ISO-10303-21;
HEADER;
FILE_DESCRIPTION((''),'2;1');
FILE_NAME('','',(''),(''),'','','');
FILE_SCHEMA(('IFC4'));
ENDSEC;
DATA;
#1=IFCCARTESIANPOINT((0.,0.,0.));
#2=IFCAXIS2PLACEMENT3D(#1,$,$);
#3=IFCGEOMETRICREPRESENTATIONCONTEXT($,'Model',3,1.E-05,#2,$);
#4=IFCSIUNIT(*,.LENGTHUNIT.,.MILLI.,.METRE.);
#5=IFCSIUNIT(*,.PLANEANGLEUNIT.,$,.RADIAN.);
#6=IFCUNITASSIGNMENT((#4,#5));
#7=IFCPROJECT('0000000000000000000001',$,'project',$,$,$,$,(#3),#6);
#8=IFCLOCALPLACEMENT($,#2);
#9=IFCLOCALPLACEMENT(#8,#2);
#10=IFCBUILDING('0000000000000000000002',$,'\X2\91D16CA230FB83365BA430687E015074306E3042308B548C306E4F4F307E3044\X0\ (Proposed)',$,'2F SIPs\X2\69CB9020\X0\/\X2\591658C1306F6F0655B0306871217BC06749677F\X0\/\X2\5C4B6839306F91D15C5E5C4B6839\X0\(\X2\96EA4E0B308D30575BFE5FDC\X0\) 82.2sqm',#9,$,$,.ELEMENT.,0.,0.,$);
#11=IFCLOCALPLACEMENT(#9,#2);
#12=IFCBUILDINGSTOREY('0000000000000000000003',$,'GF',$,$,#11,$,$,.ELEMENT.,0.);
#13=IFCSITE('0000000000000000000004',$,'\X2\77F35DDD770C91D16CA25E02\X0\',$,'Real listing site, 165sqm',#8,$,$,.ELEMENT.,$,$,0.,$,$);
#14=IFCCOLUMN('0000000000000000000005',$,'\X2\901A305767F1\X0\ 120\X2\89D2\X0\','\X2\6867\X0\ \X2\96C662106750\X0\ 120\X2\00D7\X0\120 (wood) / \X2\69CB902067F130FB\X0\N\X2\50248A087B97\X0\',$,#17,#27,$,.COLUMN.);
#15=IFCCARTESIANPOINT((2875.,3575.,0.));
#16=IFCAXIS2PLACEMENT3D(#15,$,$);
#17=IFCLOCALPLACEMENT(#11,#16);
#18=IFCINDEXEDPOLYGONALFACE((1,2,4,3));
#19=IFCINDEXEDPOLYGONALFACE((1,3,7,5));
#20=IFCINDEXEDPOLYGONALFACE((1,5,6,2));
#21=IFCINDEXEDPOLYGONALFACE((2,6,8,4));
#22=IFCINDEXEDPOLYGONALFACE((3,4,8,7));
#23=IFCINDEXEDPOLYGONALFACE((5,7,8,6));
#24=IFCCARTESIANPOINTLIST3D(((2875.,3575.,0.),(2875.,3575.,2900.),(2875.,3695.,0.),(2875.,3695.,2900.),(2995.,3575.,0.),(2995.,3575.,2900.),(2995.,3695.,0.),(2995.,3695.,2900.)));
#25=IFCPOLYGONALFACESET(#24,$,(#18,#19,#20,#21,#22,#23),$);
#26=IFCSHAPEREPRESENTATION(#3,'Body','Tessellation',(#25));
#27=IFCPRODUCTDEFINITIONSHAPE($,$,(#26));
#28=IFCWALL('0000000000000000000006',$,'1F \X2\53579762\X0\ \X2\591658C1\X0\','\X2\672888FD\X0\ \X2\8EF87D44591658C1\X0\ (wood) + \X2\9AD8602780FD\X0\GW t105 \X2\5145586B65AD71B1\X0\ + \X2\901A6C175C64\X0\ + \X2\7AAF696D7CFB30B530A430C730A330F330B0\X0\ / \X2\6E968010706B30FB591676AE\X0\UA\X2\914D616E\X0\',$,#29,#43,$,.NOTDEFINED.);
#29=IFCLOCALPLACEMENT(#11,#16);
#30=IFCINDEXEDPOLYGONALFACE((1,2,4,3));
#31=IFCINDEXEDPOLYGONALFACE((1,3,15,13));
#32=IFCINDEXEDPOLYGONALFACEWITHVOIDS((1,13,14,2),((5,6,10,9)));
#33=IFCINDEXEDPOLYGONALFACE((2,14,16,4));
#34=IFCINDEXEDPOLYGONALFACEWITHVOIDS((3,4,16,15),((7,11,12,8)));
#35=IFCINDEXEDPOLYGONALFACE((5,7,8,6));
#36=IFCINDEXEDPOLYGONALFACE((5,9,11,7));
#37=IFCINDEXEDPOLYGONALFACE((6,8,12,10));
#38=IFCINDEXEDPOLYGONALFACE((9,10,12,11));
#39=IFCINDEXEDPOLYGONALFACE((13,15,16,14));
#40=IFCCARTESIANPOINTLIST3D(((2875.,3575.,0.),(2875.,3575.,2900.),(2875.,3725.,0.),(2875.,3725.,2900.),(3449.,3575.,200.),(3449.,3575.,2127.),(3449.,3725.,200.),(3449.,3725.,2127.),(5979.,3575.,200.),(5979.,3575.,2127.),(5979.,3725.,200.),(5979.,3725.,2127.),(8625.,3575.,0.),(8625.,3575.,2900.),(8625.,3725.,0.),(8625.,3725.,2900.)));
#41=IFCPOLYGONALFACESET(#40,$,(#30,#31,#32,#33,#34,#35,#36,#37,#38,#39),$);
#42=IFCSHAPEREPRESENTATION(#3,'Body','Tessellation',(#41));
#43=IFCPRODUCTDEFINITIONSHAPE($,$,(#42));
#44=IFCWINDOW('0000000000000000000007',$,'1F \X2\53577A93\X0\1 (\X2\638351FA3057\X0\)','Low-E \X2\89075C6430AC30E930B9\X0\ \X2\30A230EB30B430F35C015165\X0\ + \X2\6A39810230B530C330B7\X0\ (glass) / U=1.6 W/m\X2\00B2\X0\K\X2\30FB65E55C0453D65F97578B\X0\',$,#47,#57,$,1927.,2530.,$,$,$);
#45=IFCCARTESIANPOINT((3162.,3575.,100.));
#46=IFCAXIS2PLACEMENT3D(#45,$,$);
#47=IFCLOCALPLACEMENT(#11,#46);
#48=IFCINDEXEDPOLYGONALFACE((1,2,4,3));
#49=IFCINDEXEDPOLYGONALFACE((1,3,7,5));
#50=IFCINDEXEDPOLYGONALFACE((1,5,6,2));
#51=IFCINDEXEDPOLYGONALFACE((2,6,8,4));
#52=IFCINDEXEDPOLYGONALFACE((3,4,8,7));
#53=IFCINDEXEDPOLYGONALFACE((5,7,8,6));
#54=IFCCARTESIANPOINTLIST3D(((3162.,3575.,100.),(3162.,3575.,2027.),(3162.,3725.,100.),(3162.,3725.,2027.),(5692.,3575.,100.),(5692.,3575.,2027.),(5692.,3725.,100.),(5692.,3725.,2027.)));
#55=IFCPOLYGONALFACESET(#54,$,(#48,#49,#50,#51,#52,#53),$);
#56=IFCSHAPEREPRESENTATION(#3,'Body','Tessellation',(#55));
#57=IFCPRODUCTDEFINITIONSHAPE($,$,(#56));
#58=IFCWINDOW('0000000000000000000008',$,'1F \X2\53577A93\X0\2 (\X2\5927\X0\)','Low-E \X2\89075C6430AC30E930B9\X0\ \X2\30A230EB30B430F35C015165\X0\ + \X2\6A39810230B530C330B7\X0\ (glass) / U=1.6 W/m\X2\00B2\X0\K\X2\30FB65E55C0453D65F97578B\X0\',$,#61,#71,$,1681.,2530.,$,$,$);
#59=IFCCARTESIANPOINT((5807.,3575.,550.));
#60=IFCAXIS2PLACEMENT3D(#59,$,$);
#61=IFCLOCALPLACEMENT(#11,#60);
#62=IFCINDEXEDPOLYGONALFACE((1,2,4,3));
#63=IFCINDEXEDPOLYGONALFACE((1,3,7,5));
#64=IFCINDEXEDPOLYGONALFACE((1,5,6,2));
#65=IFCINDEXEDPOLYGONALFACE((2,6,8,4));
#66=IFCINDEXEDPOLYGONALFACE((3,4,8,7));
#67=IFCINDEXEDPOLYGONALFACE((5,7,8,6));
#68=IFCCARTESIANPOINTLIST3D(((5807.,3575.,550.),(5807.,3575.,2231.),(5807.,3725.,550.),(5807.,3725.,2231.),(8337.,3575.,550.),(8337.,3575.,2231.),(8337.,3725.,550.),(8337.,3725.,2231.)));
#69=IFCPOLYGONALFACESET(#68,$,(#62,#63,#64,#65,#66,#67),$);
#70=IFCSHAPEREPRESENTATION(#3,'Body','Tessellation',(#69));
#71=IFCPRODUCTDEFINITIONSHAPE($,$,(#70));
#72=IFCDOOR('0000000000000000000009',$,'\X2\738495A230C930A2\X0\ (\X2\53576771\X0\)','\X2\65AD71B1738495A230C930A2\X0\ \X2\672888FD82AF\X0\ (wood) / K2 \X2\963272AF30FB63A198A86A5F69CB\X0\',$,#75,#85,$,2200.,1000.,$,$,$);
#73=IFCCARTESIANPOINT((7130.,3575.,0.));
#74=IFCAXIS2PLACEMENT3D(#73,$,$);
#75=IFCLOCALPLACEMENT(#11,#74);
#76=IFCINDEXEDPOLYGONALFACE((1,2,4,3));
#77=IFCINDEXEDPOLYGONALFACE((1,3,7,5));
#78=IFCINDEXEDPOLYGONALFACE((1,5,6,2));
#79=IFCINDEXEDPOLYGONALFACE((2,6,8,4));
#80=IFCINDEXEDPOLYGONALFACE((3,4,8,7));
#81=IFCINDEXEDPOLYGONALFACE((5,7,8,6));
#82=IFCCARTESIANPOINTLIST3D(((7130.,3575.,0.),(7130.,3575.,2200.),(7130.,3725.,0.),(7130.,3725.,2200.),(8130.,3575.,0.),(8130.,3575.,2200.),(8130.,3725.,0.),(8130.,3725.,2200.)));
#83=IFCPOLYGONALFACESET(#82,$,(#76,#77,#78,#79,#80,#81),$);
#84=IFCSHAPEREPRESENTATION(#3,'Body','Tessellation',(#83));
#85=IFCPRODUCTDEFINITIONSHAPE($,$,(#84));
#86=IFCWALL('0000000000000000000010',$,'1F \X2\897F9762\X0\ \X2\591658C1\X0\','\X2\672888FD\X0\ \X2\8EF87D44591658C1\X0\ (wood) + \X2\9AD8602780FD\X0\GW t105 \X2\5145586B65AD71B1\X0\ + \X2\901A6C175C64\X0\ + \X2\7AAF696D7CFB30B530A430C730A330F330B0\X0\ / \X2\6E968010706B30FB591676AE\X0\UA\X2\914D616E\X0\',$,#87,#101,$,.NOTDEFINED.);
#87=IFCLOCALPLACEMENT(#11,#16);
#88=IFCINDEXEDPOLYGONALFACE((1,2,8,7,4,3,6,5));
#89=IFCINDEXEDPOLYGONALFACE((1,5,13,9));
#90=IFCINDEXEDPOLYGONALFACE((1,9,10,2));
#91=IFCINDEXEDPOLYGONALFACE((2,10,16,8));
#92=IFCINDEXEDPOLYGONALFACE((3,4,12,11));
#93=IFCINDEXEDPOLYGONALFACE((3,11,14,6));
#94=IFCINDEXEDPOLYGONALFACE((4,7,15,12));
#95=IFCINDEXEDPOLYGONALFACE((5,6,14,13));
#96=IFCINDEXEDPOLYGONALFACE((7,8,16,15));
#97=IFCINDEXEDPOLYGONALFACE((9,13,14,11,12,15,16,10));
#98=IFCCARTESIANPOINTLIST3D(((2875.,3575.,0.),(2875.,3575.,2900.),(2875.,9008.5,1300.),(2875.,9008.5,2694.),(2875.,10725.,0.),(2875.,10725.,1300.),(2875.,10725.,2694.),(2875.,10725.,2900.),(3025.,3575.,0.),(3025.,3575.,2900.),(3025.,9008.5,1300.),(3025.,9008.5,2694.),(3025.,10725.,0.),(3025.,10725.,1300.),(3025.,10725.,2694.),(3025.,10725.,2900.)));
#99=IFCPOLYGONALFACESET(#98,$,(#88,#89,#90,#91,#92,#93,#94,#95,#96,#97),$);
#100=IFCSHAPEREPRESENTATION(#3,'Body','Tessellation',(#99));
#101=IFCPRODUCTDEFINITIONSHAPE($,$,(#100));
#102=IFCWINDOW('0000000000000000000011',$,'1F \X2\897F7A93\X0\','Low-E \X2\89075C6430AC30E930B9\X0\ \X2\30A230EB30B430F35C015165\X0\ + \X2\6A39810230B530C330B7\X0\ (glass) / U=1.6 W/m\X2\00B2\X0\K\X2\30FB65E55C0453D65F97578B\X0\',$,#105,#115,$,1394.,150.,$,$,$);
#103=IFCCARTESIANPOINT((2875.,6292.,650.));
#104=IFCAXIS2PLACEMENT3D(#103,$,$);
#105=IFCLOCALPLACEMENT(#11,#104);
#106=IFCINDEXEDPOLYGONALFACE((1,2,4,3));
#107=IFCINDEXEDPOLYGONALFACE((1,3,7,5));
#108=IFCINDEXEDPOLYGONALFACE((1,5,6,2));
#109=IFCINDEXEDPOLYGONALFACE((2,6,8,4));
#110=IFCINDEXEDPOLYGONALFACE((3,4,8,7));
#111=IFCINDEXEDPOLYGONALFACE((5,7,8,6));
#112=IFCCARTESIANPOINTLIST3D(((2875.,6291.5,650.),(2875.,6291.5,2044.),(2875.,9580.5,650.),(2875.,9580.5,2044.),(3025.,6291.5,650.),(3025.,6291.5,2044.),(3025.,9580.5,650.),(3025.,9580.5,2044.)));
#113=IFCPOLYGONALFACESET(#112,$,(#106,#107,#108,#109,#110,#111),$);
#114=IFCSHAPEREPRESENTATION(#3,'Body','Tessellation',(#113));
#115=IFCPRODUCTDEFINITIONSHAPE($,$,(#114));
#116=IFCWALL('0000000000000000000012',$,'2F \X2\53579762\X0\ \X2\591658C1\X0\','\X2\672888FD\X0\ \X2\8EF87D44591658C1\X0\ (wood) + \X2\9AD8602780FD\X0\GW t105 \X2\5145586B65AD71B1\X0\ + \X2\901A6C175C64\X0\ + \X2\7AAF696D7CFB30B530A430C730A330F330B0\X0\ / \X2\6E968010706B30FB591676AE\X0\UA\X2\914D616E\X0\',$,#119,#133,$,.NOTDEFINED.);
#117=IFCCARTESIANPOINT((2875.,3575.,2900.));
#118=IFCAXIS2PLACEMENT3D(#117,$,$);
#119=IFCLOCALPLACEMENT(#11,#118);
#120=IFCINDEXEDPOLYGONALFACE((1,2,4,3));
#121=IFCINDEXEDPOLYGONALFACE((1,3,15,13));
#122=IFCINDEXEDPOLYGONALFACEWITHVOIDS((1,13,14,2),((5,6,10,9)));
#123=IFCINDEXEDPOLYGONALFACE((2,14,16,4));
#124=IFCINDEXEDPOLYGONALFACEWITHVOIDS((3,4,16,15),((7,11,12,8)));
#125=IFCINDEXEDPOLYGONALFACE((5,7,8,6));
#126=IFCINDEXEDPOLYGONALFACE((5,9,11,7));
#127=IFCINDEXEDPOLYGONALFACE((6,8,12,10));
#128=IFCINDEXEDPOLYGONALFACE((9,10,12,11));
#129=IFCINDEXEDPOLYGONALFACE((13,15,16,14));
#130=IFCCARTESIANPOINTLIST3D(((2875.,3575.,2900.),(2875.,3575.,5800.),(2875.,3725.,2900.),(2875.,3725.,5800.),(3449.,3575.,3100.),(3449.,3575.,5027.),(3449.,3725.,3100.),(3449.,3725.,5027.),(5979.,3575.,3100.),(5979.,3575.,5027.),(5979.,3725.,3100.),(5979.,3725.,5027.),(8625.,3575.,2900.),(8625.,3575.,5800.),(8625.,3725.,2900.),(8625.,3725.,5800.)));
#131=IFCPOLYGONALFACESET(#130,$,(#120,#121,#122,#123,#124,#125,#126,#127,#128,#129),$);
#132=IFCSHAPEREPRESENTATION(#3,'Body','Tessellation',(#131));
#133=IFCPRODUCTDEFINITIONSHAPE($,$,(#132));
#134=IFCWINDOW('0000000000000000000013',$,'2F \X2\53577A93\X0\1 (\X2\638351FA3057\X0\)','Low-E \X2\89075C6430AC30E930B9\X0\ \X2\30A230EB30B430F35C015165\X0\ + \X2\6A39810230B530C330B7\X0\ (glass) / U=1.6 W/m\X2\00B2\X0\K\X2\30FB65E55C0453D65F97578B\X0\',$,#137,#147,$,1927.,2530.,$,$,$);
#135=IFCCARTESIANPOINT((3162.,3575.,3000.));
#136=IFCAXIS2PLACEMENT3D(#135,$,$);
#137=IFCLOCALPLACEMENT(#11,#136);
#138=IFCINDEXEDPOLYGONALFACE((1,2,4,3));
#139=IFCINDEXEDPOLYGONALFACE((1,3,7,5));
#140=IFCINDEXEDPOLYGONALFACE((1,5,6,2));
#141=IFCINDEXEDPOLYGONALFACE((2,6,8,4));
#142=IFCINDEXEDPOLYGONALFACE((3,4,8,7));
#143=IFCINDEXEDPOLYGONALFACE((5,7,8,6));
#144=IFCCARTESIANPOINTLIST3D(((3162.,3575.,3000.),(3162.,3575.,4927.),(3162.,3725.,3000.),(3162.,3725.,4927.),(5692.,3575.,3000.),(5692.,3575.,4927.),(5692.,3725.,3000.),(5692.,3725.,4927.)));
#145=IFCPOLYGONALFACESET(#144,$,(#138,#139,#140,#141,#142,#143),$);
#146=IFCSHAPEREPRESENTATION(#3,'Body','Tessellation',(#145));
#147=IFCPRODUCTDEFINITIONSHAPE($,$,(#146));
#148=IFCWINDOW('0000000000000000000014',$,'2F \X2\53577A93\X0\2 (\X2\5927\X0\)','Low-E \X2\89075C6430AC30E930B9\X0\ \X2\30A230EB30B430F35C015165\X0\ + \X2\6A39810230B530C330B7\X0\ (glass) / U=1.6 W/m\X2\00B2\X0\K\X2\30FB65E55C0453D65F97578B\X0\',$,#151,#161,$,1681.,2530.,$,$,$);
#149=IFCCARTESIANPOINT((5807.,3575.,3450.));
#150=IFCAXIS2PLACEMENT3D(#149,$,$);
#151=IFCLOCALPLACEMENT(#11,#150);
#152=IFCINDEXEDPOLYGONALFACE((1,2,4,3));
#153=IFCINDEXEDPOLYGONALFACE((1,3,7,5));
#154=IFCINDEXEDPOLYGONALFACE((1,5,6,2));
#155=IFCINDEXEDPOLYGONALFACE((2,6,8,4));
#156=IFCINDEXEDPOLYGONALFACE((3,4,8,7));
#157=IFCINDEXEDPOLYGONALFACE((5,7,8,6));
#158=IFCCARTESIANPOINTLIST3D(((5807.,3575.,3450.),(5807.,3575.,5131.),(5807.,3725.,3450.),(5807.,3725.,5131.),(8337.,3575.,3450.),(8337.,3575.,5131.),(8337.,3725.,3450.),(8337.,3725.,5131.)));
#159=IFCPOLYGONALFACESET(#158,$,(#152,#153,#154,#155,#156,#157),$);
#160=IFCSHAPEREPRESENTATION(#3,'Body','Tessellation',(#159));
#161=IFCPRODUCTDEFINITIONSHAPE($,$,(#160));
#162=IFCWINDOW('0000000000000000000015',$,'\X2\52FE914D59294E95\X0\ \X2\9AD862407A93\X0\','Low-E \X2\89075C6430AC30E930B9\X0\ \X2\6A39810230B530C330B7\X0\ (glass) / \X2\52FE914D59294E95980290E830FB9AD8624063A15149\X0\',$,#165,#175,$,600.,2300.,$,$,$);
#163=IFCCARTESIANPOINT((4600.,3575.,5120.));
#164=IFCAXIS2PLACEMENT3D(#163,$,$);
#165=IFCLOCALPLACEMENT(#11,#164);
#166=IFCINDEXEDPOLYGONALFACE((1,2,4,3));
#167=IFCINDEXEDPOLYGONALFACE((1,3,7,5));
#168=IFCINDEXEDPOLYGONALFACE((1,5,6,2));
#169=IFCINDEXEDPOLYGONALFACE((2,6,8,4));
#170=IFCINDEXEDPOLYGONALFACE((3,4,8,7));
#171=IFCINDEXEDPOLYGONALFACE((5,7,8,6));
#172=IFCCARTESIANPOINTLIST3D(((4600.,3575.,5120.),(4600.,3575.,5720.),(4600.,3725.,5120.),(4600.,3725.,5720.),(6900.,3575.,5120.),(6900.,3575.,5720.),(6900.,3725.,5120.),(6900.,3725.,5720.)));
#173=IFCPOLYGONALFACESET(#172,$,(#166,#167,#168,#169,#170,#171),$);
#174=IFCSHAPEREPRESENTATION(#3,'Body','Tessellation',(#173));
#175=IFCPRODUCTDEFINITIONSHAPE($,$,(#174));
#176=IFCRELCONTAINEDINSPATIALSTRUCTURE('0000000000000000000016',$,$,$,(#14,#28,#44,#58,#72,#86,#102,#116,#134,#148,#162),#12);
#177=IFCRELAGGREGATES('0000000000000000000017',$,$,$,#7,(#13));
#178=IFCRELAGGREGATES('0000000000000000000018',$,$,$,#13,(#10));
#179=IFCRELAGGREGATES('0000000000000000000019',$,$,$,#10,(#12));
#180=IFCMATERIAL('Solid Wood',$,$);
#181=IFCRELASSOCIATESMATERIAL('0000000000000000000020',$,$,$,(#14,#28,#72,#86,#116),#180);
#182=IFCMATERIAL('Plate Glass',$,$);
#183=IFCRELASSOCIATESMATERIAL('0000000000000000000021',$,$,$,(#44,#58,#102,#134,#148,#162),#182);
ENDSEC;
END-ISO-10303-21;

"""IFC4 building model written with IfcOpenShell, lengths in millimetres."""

from ifc_helpers import new_model, si_unit, frame, frame_2d, origin, place, context, project, spatial, rectangle, extrude, material, element, fill, save


model = new_model("IFC4")

# Units and contexts
model_context = context("Model", 3, precision=1e-05, world=origin())
ifc_project = project(units=[si_unit("LENGTHUNIT", "METRE", prefix="MILLI"), si_unit("PLANEANGLEUNIT", "RADIAN")], contexts=[model_context])

# Site, building, storey
site_placement = place(None, origin())
site = spatial("IfcSite", under=ifc_project, at=site_placement, Name="石川県金沢市", ObjectType="Real listing site, 165sqm", CompositionType="ELEMENT", RefElevation=0.0)
building_placement = place(site_placement, origin())
building = spatial("IfcBuilding", under=site, at=building_placement, Name="金沢・茶室と縁側のある和の住まい (Proposed)", ObjectType="2F SIPs構造/外壁は漆喰と無節杉板/屋根は金属屋根(雪下ろし対応) 82.2sqm", CompositionType="ELEMENT", ElevationOfRefHeight=0.0, ElevationOfTerrain=0.0)
storey_placement = place(building_placement, origin())
storey = spatial("IfcBuildingStorey", under=building, at=storey_placement, Name="GF", CompositionType="ELEMENT", Elevation=0.0)

# Column
ifc_material_1 = material(Name="Solid Wood")
column_placement = place(storey_placement, frame((2875.0, 3575.0, 0.0)))
element("IfcColumn", 1, at=column_placement, inside=storey, material=ifc_material_1, Name="通し柱 120角", Description="桧 集成材 120×120 (wood) / 構造柱・N値計算", PredefinedType="COLUMN", context=model_context, shape_type="SweptSolid", body=[
    extrude(rectangle(XDim=120.0, YDim=120.0, at=frame_2d((60.0, 60.0))), frame((2875.0, 3575.0, 0.0)), (0.0, 0.0, 1.0), 2900.0),
])

# Wall, openings, windows, door
wall_1_placement = place(storey_placement, frame((2875.0, 3575.0, 0.0)))
wall_1 = element("IfcWall", 2, at=wall_1_placement, inside=storey, material=ifc_material_1, Name="1F 南面 外壁", Description="木製 軸組外壁 (wood) + 高性能GW t105 充填断熱 + 通気層 + 窯業系サイディング / 準耐火・外皮UA配慮", PredefinedType="NOTDEFINED", context=model_context, shape_type="SweptSolid", body=[
    extrude(rectangle(XDim=5750.0, YDim=150.0, at=frame_2d((2875.0, 75.0))), frame((2875.0, 3575.0, 0.0)), (0.0, 0.0, 1.0), 2900.0),
])
opening_1_placement = place(storey_placement, frame((3162.0, 3575.0, 100.0)))
opening_1 = element("IfcOpeningElement", 3, at=opening_1_placement, cuts=wall_1, PredefinedType="NOTDEFINED", context=model_context, shape_type="SweptSolid", body=[
    extrude(rectangle(XDim=2530.0, YDim=150.0, at=frame_2d((1265.0, 75.0))), frame((3162.0, 3575.0, 100.0)), (0.0, 0.0, 1.0), 1927.0),
])
opening_2_placement = place(storey_placement, frame((5807.0, 3575.0, 550.0)))
opening_2 = element("IfcOpeningElement", 4, at=opening_2_placement, cuts=wall_1, PredefinedType="NOTDEFINED", context=model_context, shape_type="SweptSolid", body=[
    extrude(rectangle(XDim=2530.0, YDim=150.0, at=frame_2d((1265.0, 75.0))), frame((5807.0, 3575.0, 550.0)), (0.0, 0.0, 1.0), 1681.0),
])
opening_3_placement = place(storey_placement, frame((7130.0, 3575.0, 0.0)))
opening_3 = element("IfcOpeningElement", 5, at=opening_3_placement, cuts=wall_1, PredefinedType="NOTDEFINED", context=model_context, shape_type="SweptSolid", body=[
    extrude(rectangle(XDim=1000.0, YDim=150.0, at=frame_2d((500.0, 75.0))), frame((7130.0, 3575.0, 0.0)), (0.0, 0.0, 1.0), 2200.0),
])
ifc_material_2 = material(Name="Plate Glass")
window_1_placement = place(storey_placement, frame((3162.0, 3575.0, 100.0)))
window_1 = element("IfcWindow", 6, at=window_1_placement, inside=storey, material=ifc_material_2, Name="1F 南窓1 (掃出し)", Description="Low-E 複層ガラス アルゴン封入 + 樹脂サッシ (glass) / U=1.6 W/m²K・日射取得型", OverallHeight=1927.0, OverallWidth=2530.0, context=model_context, shape_type="SweptSolid", body=[
    extrude(rectangle(XDim=2530.0, YDim=150.0, at=frame_2d((1265.0, 75.0))), frame((3162.0, 3575.0, 100.0)), (0.0, 0.0, 1.0), 1927.0),
])
fill(opening_1, window_1)
window_2_placement = place(storey_placement, frame((5807.0, 3575.0, 550.0)))
window_2 = element("IfcWindow", 7, at=window_2_placement, inside=storey, material=ifc_material_2, Name="1F 南窓2 (大)", Description="Low-E 複層ガラス アルゴン封入 + 樹脂サッシ (glass) / U=1.6 W/m²K・日射取得型", OverallHeight=1681.0, OverallWidth=2530.0, context=model_context, shape_type="SweptSolid", body=[
    extrude(rectangle(XDim=2530.0, YDim=150.0, at=frame_2d((1265.0, 75.0))), frame((5807.0, 3575.0, 550.0)), (0.0, 0.0, 1.0), 1681.0),
])
fill(opening_2, window_2)
door_placement = place(storey_placement, frame((7130.0, 3575.0, 0.0)))
door = element("IfcDoor", 8, at=door_placement, inside=storey, material=ifc_material_1, Name="玄関ドア (南東)", Description="断熱玄関ドア 木製芯 (wood) / K2 防犯・採風機構", OverallHeight=2200.0, OverallWidth=1000.0, context=model_context, shape_type="SweptSolid", body=[
    extrude(rectangle(XDim=1000.0, YDim=150.0, at=frame_2d((500.0, 75.0))), frame((7130.0, 3575.0, 0.0)), (0.0, 0.0, 1.0), 2200.0),
])
fill(opening_3, door)

# Wall, opening, window
wall_2_placement = place(storey_placement, frame((2875.0, 3575.0, 0.0)))
wall_2 = element("IfcWall", 9, at=wall_2_placement, inside=storey, material=ifc_material_1, Name="1F 西面 外壁", Description="木製 軸組外壁 (wood) + 高性能GW t105 充填断熱 + 通気層 + 窯業系サイディング / 準耐火・外皮UA配慮", PredefinedType="NOTDEFINED", context=model_context, shape_type="SweptSolid", body=[
    extrude(rectangle(XDim=150.0, YDim=7150.0, at=frame_2d((75.0, 3575.0))), frame((2875.0, 3575.0, 0.0)), (0.0, 0.0, 1.0), 2900.0),
])
opening_4_placement = place(storey_placement, frame((2875.0, 6292.0, 650.0)))
opening_4 = element("IfcOpeningElement", 10, at=opening_4_placement, cuts=wall_2, PredefinedType="NOTDEFINED", context=model_context, shape_type="SweptSolid", body=[
    extrude(rectangle(XDim=150.0, YDim=3289.0, at=frame_2d((75.0, 1644.0))), frame((2875.0, 6292.0, 650.0)), (0.0, 0.0, 1.0), 1394.0),
])
window_3_placement = place(storey_placement, frame((2875.0, 6292.0, 650.0)))
window_3 = element("IfcWindow", 11, at=window_3_placement, inside=storey, material=ifc_material_2, Name="1F 西窓", Description="Low-E 複層ガラス アルゴン封入 + 樹脂サッシ (glass) / U=1.6 W/m²K・日射取得型", OverallHeight=1394.0, OverallWidth=150.0, context=model_context, shape_type="SweptSolid", body=[
    extrude(rectangle(XDim=150.0, YDim=3289.0, at=frame_2d((75.0, 1644.0))), frame((2875.0, 6292.0, 650.0)), (0.0, 0.0, 1.0), 1394.0),
])
fill(opening_4, window_3)

# Wall, openings, windows
wall_3_placement = place(storey_placement, frame((2875.0, 3575.0, 2900.0)))
wall_3 = element("IfcWall", 12, at=wall_3_placement, inside=storey, material=ifc_material_1, Name="2F 南面 外壁", Description="木製 軸組外壁 (wood) + 高性能GW t105 充填断熱 + 通気層 + 窯業系サイディング / 準耐火・外皮UA配慮", PredefinedType="NOTDEFINED", context=model_context, shape_type="SweptSolid", body=[
    extrude(rectangle(XDim=5750.0, YDim=150.0, at=frame_2d((2875.0, 75.0))), frame((2875.0, 3575.0, 2900.0)), (0.0, 0.0, 1.0), 2900.0),
])
opening_5_placement = place(storey_placement, frame((3162.0, 3575.0, 3000.0)))
opening_5 = element("IfcOpeningElement", 13, at=opening_5_placement, cuts=wall_3, PredefinedType="NOTDEFINED", context=model_context, shape_type="SweptSolid", body=[
    extrude(rectangle(XDim=2530.0, YDim=150.0, at=frame_2d((1265.0, 75.0))), frame((3162.0, 3575.0, 3000.0)), (0.0, 0.0, 1.0), 1927.0),
])
opening_6_placement = place(storey_placement, frame((5807.0, 3575.0, 3450.0)))
opening_6 = element("IfcOpeningElement", 14, at=opening_6_placement, cuts=wall_3, PredefinedType="NOTDEFINED", context=model_context, shape_type="SweptSolid", body=[
    extrude(rectangle(XDim=2530.0, YDim=150.0, at=frame_2d((1265.0, 75.0))), frame((5807.0, 3575.0, 3450.0)), (0.0, 0.0, 1.0), 1681.0),
])
opening_7_placement = place(storey_placement, frame((4600.0, 3575.0, 5120.0)))
opening_7 = element("IfcOpeningElement", 15, at=opening_7_placement, cuts=wall_3, PredefinedType="NOTDEFINED", context=model_context, shape_type="SweptSolid", body=[
    extrude(rectangle(XDim=2300.0, YDim=150.0, at=frame_2d((1150.0, 75.0))), frame((4600.0, 3575.0, 5120.0)), (0.0, 0.0, 1.0), 600.0),
])
window_4_placement = place(storey_placement, frame((3162.0, 3575.0, 3000.0)))
window_4 = element("IfcWindow", 16, at=window_4_placement, inside=storey, material=ifc_material_2, Name="2F 南窓1 (掃出し)", Description="Low-E 複層ガラス アルゴン封入 + 樹脂サッシ (glass) / U=1.6 W/m²K・日射取得型", OverallHeight=1927.0, OverallWidth=2530.0, context=model_context, shape_type="SweptSolid", body=[
    extrude(rectangle(XDim=2530.0, YDim=150.0, at=frame_2d((1265.0, 75.0))), frame((3162.0, 3575.0, 3000.0)), (0.0, 0.0, 1.0), 1927.0),
])
fill(opening_5, window_4)
window_5_placement = place(storey_placement, frame((5807.0, 3575.0, 3450.0)))
window_5 = element("IfcWindow", 17, at=window_5_placement, inside=storey, material=ifc_material_2, Name="2F 南窓2 (大)", Description="Low-E 複層ガラス アルゴン封入 + 樹脂サッシ (glass) / U=1.6 W/m²K・日射取得型", OverallHeight=1681.0, OverallWidth=2530.0, context=model_context, shape_type="SweptSolid", body=[
    extrude(rectangle(XDim=2530.0, YDim=150.0, at=frame_2d((1265.0, 75.0))), frame((5807.0, 3575.0, 3450.0)), (0.0, 0.0, 1.0), 1681.0),
])
fill(opening_6, window_5)
window_6_placement = place(storey_placement, frame((4600.0, 3575.0, 5120.0)))
window_6 = element("IfcWindow", 18, at=window_6_placement, inside=storey, material=ifc_material_2, Name="勾配天井 高所窓", Description="Low-E 複層ガラス 樹脂サッシ (glass) / 勾配天井頂部・高所採光", OverallHeight=600.0, OverallWidth=2300.0, context=model_context, shape_type="SweptSolid", body=[
    extrude(rectangle(XDim=2300.0, YDim=150.0, at=frame_2d((1150.0, 75.0))), frame((4600.0, 3575.0, 5120.0)), (0.0, 0.0, 1.0), 600.0),
])
fill(opening_7, window_6)

save(model, "model.ifc")
